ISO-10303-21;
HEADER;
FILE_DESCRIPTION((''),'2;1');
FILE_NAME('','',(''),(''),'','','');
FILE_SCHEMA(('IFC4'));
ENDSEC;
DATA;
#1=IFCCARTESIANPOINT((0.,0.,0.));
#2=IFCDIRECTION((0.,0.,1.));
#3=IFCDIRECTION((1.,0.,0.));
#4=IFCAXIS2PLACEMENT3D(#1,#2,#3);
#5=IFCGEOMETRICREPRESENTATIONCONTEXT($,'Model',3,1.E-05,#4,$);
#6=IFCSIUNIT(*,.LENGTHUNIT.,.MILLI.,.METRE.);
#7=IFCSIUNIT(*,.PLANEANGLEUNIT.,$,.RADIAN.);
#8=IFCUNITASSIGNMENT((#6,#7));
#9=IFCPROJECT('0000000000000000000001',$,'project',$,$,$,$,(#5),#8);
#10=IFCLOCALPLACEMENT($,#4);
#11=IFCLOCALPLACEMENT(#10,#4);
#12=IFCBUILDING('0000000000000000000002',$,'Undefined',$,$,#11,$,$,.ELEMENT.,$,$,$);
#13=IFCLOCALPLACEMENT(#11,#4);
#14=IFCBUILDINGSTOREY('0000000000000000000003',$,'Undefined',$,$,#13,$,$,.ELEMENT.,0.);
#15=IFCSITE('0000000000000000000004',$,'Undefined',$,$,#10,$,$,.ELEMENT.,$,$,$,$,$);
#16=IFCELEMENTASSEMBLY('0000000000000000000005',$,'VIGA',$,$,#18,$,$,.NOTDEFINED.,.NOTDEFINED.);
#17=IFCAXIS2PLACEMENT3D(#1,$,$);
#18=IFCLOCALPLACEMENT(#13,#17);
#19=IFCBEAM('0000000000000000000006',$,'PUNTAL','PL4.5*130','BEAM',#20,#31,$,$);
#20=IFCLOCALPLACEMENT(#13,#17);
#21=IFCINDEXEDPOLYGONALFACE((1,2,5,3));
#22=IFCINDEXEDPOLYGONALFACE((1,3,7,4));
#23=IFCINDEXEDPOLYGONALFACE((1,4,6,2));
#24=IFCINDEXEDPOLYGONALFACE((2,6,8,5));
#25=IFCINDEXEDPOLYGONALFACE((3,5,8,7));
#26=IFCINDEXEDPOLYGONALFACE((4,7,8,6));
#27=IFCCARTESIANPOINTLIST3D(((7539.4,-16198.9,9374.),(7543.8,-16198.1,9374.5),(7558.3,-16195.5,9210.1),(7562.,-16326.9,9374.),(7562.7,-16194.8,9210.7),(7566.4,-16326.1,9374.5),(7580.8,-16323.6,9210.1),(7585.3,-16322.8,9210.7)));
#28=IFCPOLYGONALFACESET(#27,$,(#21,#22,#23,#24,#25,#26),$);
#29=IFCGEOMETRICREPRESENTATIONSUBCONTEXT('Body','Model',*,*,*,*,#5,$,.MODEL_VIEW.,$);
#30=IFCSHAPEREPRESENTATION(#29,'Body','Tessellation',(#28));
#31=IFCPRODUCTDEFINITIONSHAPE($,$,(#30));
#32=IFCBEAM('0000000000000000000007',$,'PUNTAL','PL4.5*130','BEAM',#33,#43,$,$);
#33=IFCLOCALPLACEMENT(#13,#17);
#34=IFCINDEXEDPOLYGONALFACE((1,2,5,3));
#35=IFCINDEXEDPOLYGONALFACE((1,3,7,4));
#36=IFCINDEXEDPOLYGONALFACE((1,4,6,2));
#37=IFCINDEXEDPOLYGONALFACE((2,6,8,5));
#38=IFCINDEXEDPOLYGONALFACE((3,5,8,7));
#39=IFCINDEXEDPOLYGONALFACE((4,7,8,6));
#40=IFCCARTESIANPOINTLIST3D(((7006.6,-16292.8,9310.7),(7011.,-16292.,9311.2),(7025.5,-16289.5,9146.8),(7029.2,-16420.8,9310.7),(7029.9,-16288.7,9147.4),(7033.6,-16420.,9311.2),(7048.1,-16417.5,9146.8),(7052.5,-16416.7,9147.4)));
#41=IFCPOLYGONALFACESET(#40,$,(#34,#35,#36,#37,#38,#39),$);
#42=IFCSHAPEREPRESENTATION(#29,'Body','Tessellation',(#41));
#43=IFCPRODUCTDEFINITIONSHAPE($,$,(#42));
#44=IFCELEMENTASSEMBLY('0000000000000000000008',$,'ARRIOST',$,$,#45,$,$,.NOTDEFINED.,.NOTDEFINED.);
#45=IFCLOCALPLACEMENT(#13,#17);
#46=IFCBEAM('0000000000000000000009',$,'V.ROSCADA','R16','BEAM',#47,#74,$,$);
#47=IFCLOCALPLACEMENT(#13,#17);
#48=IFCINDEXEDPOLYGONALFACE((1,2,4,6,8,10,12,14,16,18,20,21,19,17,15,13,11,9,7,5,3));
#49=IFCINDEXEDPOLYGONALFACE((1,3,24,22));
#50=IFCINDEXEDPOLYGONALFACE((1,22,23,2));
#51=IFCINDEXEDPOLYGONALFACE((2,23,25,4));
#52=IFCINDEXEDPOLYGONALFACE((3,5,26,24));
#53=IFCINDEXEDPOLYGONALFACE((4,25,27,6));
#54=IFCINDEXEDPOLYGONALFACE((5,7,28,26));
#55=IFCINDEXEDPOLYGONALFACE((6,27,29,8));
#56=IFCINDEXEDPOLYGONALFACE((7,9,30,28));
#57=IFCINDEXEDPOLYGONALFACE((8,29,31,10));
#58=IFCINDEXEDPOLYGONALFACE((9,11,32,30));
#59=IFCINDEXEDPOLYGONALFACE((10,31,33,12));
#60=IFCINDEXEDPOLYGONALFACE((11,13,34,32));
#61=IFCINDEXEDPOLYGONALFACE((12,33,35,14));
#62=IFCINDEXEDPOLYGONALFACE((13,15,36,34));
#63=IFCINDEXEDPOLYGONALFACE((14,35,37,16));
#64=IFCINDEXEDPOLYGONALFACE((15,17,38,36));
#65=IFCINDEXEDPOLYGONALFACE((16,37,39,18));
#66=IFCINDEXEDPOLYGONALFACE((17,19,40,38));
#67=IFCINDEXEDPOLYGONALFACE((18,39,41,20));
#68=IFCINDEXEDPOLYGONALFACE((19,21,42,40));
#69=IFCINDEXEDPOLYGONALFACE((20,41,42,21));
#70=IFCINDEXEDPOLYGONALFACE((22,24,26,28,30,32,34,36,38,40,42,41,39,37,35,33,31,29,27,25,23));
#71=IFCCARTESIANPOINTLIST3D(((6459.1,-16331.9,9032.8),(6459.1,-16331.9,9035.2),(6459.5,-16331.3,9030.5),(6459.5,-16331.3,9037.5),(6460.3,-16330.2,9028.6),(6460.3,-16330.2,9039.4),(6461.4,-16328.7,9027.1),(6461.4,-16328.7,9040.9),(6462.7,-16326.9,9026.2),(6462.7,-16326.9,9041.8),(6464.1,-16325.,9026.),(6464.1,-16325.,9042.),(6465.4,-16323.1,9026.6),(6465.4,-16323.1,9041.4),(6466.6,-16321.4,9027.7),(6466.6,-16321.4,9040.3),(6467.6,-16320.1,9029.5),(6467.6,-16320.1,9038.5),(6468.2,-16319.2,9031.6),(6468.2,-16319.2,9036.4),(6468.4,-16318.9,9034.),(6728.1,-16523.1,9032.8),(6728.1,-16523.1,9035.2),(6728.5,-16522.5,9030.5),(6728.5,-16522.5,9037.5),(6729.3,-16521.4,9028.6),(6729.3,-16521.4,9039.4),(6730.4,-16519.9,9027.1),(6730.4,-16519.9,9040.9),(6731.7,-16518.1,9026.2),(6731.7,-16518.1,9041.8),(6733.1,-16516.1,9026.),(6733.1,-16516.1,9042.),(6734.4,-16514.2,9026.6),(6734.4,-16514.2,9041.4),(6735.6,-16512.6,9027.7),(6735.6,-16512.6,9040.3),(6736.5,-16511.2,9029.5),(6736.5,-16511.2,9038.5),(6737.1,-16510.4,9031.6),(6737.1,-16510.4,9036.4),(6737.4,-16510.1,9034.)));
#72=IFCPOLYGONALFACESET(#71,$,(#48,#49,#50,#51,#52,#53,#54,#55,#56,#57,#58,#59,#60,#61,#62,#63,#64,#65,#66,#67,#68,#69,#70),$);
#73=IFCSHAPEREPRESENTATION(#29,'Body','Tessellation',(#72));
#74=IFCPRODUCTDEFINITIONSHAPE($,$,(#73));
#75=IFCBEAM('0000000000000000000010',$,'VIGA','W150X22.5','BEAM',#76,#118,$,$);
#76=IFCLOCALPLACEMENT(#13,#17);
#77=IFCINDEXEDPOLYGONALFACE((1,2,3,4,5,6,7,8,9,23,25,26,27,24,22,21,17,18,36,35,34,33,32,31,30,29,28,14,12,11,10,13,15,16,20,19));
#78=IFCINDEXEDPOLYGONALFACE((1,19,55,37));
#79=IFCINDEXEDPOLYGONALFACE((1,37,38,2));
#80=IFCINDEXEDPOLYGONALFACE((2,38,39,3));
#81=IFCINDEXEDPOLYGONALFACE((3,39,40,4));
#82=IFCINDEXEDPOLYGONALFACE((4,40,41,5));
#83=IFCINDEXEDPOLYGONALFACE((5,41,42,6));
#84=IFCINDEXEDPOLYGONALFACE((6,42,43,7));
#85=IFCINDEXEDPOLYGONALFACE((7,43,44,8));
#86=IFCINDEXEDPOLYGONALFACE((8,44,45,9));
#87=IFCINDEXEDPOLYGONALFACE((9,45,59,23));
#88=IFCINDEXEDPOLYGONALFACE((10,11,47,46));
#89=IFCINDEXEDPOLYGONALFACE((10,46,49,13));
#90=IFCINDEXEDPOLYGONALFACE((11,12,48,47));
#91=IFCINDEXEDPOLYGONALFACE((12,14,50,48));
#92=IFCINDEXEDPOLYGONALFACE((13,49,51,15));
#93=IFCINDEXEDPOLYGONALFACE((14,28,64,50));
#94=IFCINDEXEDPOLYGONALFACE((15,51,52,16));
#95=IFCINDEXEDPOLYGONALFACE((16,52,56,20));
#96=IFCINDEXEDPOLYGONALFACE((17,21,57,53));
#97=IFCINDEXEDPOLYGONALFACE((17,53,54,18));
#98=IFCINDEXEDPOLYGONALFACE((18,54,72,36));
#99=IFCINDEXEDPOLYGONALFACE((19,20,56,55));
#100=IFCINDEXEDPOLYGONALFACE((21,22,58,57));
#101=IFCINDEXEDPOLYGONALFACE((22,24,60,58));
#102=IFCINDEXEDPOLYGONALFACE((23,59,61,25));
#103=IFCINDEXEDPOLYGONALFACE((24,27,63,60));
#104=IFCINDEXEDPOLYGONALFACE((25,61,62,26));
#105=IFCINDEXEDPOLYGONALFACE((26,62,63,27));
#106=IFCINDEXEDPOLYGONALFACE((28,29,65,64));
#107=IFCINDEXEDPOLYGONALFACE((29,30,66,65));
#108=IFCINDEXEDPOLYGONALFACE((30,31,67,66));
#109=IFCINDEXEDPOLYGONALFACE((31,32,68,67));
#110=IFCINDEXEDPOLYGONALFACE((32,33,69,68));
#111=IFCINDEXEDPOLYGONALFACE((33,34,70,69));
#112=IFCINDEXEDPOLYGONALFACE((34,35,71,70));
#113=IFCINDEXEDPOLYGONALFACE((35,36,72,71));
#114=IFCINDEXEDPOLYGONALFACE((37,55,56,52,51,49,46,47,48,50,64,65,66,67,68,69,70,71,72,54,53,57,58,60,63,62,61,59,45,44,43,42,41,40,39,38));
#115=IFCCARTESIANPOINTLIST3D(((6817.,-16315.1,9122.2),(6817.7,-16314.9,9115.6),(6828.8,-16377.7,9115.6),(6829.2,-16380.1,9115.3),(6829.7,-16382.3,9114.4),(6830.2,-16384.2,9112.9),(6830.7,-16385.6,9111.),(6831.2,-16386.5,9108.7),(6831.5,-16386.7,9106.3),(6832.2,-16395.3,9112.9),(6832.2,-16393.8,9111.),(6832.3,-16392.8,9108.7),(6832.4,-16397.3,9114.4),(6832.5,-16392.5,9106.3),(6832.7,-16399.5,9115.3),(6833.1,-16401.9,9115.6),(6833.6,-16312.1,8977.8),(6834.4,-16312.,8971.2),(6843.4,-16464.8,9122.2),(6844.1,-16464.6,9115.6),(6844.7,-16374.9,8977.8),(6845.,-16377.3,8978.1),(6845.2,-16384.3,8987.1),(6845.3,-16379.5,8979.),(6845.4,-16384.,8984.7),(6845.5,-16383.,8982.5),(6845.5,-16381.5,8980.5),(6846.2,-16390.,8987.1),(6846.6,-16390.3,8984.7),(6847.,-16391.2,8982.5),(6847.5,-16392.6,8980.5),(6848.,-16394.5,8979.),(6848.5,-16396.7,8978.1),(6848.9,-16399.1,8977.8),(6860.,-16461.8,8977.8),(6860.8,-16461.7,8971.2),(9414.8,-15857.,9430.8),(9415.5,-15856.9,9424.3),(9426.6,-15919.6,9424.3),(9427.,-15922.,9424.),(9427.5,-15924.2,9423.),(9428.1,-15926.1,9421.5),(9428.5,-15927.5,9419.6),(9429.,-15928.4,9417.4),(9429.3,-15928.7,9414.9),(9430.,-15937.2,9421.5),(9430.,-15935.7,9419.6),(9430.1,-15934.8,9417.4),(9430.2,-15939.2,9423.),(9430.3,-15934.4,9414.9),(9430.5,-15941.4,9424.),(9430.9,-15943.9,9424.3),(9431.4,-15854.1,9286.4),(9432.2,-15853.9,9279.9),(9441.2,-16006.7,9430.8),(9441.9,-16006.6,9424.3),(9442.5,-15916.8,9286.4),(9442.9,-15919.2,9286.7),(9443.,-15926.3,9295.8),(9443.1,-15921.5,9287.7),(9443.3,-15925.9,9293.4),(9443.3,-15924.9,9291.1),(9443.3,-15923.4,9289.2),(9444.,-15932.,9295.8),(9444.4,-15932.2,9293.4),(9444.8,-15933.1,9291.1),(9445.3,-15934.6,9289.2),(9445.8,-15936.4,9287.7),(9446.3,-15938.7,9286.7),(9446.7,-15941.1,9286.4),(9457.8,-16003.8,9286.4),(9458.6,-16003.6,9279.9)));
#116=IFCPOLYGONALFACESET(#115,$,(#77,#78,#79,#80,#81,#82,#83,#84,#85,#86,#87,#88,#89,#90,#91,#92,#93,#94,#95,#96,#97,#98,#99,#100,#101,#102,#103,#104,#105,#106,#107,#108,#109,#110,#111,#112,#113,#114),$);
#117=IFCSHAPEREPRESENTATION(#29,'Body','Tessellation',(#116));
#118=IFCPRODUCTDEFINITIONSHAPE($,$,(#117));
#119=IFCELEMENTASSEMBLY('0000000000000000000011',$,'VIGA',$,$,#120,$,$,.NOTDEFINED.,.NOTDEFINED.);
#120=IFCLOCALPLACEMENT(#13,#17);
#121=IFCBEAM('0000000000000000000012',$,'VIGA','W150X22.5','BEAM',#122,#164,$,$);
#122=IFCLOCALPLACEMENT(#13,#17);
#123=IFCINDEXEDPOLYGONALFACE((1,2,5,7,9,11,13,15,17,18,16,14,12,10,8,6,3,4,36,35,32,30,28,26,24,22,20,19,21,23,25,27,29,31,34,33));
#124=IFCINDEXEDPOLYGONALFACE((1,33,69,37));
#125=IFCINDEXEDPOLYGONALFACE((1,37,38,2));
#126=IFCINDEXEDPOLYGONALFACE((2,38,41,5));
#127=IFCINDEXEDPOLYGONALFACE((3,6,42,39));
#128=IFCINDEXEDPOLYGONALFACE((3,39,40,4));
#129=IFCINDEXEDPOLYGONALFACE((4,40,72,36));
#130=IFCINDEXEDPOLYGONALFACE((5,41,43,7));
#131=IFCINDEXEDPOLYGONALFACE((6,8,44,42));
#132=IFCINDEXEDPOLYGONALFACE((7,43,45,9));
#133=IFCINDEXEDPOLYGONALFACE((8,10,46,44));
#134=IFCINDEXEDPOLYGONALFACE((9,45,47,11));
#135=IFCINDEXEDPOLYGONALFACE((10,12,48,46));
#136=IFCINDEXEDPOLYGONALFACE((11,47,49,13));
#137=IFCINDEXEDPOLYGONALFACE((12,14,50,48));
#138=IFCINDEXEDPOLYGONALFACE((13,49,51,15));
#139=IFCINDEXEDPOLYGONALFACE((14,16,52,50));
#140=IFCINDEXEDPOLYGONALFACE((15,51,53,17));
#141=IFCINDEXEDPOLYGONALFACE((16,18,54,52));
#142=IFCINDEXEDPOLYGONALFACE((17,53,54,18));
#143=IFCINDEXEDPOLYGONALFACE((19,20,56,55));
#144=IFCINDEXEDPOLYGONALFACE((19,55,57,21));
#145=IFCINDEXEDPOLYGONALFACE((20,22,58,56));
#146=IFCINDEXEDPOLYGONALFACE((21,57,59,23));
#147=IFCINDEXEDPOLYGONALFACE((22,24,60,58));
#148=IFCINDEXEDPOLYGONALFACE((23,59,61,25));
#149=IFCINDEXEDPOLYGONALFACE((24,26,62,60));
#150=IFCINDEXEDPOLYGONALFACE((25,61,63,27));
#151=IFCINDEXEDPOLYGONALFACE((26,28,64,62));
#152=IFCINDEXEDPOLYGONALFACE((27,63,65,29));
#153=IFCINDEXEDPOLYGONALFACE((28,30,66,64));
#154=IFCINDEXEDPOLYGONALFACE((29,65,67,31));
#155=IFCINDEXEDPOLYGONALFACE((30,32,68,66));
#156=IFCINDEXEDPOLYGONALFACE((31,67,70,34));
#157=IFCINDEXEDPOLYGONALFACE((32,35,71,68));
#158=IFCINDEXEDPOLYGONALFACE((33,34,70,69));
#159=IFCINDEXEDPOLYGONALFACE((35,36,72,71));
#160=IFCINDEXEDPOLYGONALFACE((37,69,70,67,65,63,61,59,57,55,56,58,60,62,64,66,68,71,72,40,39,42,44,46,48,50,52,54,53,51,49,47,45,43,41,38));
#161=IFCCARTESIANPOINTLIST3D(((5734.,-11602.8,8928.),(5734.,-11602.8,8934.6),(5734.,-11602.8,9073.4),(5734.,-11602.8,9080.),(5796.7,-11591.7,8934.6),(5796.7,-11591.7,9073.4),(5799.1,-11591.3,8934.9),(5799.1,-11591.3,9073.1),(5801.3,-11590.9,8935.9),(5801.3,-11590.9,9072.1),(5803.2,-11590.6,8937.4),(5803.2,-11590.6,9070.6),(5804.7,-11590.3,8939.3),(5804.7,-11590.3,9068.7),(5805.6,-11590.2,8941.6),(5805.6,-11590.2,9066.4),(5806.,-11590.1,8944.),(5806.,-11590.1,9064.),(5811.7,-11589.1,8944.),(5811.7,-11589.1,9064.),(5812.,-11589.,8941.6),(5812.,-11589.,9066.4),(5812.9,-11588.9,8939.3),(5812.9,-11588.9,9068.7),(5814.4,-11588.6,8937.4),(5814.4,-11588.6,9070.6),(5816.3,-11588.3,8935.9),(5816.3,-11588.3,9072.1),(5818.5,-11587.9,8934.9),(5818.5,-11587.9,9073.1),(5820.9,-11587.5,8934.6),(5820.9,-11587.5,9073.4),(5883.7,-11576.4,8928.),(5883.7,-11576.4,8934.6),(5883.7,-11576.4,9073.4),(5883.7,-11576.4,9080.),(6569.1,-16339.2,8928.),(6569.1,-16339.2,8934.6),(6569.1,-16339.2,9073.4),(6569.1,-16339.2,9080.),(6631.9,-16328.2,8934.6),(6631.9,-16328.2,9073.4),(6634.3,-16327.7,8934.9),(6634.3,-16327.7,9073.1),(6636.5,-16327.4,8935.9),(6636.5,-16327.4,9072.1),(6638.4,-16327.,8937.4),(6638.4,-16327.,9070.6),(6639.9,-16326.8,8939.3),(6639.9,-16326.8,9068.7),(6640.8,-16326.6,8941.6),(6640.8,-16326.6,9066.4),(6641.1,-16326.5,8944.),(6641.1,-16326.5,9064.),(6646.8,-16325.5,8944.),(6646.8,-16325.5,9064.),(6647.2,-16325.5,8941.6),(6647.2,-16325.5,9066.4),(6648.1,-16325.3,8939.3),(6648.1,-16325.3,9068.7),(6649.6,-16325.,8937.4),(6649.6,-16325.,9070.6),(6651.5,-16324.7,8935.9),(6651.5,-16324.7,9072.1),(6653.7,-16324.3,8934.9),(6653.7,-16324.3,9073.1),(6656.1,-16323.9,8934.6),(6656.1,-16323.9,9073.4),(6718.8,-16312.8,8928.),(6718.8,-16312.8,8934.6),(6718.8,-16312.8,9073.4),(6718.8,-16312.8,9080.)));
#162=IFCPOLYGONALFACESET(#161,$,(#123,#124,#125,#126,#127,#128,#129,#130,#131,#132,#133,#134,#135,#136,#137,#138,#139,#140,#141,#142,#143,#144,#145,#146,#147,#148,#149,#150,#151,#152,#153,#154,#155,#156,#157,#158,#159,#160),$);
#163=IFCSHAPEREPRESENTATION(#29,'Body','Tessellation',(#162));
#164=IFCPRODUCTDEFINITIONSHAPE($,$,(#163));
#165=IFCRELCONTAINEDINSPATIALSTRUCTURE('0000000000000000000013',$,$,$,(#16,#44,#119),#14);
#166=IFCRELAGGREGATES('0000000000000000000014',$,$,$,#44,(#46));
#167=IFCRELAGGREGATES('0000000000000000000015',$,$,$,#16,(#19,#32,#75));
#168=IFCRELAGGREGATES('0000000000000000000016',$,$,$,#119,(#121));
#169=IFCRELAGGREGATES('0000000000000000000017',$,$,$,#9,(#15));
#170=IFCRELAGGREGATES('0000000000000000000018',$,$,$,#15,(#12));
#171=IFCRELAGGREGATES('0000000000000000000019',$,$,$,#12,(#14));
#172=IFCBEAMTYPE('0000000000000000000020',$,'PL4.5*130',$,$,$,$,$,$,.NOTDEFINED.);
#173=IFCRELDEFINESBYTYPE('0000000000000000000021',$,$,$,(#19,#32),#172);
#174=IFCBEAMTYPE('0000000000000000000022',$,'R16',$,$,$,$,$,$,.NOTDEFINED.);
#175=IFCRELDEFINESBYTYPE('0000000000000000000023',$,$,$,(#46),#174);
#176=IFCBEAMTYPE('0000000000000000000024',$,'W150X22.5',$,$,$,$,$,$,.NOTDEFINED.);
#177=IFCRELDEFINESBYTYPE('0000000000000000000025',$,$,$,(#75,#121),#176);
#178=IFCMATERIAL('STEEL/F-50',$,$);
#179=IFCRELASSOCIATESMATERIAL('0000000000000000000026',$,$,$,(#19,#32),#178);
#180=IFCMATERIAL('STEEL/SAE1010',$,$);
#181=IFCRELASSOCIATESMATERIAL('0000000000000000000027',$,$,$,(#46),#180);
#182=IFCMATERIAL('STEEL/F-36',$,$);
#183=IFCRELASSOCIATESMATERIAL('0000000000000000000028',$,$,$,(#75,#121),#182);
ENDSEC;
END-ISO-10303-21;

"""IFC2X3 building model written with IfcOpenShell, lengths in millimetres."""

from ifc_helpers import new_model, si_unit, frame, origin_with_axes, origin_2d_with_axis, place, context, subcontext, project, spatial, rectangle, circle, i_section, extrude, material, type_object, element, aggregate, save


model = new_model("IFC2X3")

# Units and contexts
model_context = context("Model", 3, precision=1e-05, world=origin_with_axes())
body_context = subcontext(model_context, "Body", "Model", "MODEL_VIEW")
ifc_project = project(units=[si_unit("LENGTHUNIT", "METRE", prefix="MILLI"), si_unit("PLANEANGLEUNIT", "RADIAN")], contexts=[model_context])

# Site, building, storey
site_placement = place(None, origin_with_axes())
site = spatial("IfcSite", under=ifc_project, at=site_placement, Name="Undefined", CompositionType="ELEMENT")
building_placement = place(site_placement, origin_with_axes())
building = spatial("IfcBuilding", under=site, at=building_placement, Name="Undefined", CompositionType="ELEMENT")
storey_placement = place(building_placement, origin_with_axes())
storey = spatial("IfcBuildingStorey", under=building, at=storey_placement, Name="Undefined", CompositionType="ELEMENT", Elevation=0.0)

# Element assembly, beams
assembly_1_placement = place(storey_placement, origin_with_axes())
assembly_1 = element("IfcElementAssembly", 1, at=assembly_1_placement, inside=storey, Name="VIGA", AssemblyPlace="NOTDEFINED", PredefinedType="NOTDEFINED")
ifc_material_1 = material(Name="STEEL/F-50")
beam_type_1 = type_object("IfcBeamType", Name="PL4.5*130", PredefinedType="NOTDEFINED")
beam_1_placement = place(assembly_1_placement, frame((7571.8, -16259.2, 9210.4), z_axis=(0.173648, -0.984808, 0.0), x_axis=(-0.114445, -0.02018, 0.993225)))
beam_1 = element("IfcBeam", 2, at=beam_1_placement, type_object=beam_type_1, material=ifc_material_1, Name="PUNTAL", Description="PL4.5*130", ObjectType="BEAM", context=body_context, shape_type="SweptSolid", body=[
    extrude(rectangle(XDim=4.5, YDim=130.0, at=origin_2d_with_axis()), frame((165.0, 0.0, 0.0), z_axis=(-1.0, 0.0, 0.0), x_axis=(0.0, -1.0, 0.0)), (0.0, 0.0, 1.0), 165.0),
])
beam_2_placement = place(assembly_1_placement, frame((7039.0, -16353.1, 9147.1), z_axis=(0.173648, -0.984808, 0.0), x_axis=(-0.114445, -0.02018, 0.993225)))
beam_2 = element("IfcBeam", 3, at=beam_2_placement, type_object=beam_type_1, material=ifc_material_1, Name="PUNTAL", Description="PL4.5*130", ObjectType="BEAM", context=body_context, shape_type="SweptSolid", body=[
    extrude(rectangle(XDim=4.5, YDim=130.0, at=origin_2d_with_axis()), frame((165.0, 0.0, 0.0), z_axis=(-1.0, 0.0, 0.0), x_axis=(0.0, -1.0, 0.0)), (0.0, 0.0, 1.0), 165.0),
])

# Element assembly, beam
beam_type_2 = type_object("IfcBeamType", Name="R16", PredefinedType="NOTDEFINED")
assembly_2_placement = place(storey_placement, origin_with_axes())
assembly_2 = element("IfcElementAssembly", 4, at=assembly_2_placement, inside=storey, Name="ARRIOST", AssemblyPlace="NOTDEFINED", PredefinedType="NOTDEFINED")
ifc_material_2 = material(Name="STEEL/SAE1010")
beam_3_placement = place(assembly_2_placement, frame((6463.7, -16325.5, 9034.0), z_axis=(-0.000001, 0.000001, -1.0), x_axis=(0.81514, -0.579264, -0.000001)))
beam_3 = element("IfcBeam", 5, at=beam_3_placement, type_object=beam_type_2, material=ifc_material_2, Name="V.ROSCADA", Description="R16", ObjectType="BEAM", context=body_context, shape_type="SweptSolid", body=[
    extrude(circle(Radius=8.0, at=origin_2d_with_axis()), frame((330.0, 0.0, 0.0), z_axis=(-1.0, 0.0, 0.0), x_axis=(0.0, -1.0, 0.0)), (0.0, 0.0, 1.0), 330.0),
])
aggregate(assembly_2, [beam_3])

# Beam
ifc_material_3 = material(Name="STEEL/F-36")
beam_type_3 = type_object("IfcBeamType", Name="W150X22.5", PredefinedType="NOTDEFINED")
beam_4_placement = place(assembly_1_placement, frame((6838.9, -16388.4, 9046.7), z_axis=(0.114445, 0.02018, -0.993225), x_axis=(0.978135, 0.172472, 0.11621)))
beam_4 = element("IfcBeam", 6, at=beam_4_placement, type_object=beam_type_3, material=ifc_material_3, Name="VIGA", Description="W150X22.5", ObjectType="BEAM", context=body_context, shape_type="SweptSolid", body=[
    extrude(i_section(OverallWidth=152.0, OverallDepth=152.0, WebThickness=5.8, FlangeThickness=6.6, FilletRadius=9.4, at=origin_2d_with_axis()), frame((2655.9, 0.0, 0.0), z_axis=(-1.0, 0.0, 0.0), x_axis=(0.0, -1.0, 0.0)), (0.0, 0.0, 1.0), 2655.9),
])

# Element assembly, beam
assembly_3_placement = place(storey_placement, origin_with_axes())
assembly_3 = element("IfcElementAssembly", 7, at=assembly_3_placement, inside=storey, Name="VIGA", AssemblyPlace="NOTDEFINED", PredefinedType="NOTDEFINED")
beam_5_placement = place(assembly_3_placement, frame((6644.0, -16326.0, 9004.0), z_axis=(0.0, 0.0, 1.0), x_axis=(-0.173649, 0.984808, 0.0)))
beam_5 = element("IfcBeam", 8, at=beam_5_placement, type_object=beam_type_3, material=ifc_material_3, Name="VIGA", Description="W150X22.5", ObjectType="BEAM", context=body_context, shape_type="SweptSolid", body=[
    extrude(i_section(OverallWidth=152.0, OverallDepth=152.0, WebThickness=5.8, FlangeThickness=6.6, FilletRadius=9.4, at=origin_2d_with_axis()), frame((4809.5, 0.0, 0.0), z_axis=(-1.0, 0.0, 0.0), x_axis=(0.0, -1.0, 0.0)), (0.0, 0.0, 1.0), 4809.5),
])

aggregate(assembly_1, [beam_1, beam_2, beam_4])
aggregate(assembly_3, [beam_5])

save(model, "model.ifc")
